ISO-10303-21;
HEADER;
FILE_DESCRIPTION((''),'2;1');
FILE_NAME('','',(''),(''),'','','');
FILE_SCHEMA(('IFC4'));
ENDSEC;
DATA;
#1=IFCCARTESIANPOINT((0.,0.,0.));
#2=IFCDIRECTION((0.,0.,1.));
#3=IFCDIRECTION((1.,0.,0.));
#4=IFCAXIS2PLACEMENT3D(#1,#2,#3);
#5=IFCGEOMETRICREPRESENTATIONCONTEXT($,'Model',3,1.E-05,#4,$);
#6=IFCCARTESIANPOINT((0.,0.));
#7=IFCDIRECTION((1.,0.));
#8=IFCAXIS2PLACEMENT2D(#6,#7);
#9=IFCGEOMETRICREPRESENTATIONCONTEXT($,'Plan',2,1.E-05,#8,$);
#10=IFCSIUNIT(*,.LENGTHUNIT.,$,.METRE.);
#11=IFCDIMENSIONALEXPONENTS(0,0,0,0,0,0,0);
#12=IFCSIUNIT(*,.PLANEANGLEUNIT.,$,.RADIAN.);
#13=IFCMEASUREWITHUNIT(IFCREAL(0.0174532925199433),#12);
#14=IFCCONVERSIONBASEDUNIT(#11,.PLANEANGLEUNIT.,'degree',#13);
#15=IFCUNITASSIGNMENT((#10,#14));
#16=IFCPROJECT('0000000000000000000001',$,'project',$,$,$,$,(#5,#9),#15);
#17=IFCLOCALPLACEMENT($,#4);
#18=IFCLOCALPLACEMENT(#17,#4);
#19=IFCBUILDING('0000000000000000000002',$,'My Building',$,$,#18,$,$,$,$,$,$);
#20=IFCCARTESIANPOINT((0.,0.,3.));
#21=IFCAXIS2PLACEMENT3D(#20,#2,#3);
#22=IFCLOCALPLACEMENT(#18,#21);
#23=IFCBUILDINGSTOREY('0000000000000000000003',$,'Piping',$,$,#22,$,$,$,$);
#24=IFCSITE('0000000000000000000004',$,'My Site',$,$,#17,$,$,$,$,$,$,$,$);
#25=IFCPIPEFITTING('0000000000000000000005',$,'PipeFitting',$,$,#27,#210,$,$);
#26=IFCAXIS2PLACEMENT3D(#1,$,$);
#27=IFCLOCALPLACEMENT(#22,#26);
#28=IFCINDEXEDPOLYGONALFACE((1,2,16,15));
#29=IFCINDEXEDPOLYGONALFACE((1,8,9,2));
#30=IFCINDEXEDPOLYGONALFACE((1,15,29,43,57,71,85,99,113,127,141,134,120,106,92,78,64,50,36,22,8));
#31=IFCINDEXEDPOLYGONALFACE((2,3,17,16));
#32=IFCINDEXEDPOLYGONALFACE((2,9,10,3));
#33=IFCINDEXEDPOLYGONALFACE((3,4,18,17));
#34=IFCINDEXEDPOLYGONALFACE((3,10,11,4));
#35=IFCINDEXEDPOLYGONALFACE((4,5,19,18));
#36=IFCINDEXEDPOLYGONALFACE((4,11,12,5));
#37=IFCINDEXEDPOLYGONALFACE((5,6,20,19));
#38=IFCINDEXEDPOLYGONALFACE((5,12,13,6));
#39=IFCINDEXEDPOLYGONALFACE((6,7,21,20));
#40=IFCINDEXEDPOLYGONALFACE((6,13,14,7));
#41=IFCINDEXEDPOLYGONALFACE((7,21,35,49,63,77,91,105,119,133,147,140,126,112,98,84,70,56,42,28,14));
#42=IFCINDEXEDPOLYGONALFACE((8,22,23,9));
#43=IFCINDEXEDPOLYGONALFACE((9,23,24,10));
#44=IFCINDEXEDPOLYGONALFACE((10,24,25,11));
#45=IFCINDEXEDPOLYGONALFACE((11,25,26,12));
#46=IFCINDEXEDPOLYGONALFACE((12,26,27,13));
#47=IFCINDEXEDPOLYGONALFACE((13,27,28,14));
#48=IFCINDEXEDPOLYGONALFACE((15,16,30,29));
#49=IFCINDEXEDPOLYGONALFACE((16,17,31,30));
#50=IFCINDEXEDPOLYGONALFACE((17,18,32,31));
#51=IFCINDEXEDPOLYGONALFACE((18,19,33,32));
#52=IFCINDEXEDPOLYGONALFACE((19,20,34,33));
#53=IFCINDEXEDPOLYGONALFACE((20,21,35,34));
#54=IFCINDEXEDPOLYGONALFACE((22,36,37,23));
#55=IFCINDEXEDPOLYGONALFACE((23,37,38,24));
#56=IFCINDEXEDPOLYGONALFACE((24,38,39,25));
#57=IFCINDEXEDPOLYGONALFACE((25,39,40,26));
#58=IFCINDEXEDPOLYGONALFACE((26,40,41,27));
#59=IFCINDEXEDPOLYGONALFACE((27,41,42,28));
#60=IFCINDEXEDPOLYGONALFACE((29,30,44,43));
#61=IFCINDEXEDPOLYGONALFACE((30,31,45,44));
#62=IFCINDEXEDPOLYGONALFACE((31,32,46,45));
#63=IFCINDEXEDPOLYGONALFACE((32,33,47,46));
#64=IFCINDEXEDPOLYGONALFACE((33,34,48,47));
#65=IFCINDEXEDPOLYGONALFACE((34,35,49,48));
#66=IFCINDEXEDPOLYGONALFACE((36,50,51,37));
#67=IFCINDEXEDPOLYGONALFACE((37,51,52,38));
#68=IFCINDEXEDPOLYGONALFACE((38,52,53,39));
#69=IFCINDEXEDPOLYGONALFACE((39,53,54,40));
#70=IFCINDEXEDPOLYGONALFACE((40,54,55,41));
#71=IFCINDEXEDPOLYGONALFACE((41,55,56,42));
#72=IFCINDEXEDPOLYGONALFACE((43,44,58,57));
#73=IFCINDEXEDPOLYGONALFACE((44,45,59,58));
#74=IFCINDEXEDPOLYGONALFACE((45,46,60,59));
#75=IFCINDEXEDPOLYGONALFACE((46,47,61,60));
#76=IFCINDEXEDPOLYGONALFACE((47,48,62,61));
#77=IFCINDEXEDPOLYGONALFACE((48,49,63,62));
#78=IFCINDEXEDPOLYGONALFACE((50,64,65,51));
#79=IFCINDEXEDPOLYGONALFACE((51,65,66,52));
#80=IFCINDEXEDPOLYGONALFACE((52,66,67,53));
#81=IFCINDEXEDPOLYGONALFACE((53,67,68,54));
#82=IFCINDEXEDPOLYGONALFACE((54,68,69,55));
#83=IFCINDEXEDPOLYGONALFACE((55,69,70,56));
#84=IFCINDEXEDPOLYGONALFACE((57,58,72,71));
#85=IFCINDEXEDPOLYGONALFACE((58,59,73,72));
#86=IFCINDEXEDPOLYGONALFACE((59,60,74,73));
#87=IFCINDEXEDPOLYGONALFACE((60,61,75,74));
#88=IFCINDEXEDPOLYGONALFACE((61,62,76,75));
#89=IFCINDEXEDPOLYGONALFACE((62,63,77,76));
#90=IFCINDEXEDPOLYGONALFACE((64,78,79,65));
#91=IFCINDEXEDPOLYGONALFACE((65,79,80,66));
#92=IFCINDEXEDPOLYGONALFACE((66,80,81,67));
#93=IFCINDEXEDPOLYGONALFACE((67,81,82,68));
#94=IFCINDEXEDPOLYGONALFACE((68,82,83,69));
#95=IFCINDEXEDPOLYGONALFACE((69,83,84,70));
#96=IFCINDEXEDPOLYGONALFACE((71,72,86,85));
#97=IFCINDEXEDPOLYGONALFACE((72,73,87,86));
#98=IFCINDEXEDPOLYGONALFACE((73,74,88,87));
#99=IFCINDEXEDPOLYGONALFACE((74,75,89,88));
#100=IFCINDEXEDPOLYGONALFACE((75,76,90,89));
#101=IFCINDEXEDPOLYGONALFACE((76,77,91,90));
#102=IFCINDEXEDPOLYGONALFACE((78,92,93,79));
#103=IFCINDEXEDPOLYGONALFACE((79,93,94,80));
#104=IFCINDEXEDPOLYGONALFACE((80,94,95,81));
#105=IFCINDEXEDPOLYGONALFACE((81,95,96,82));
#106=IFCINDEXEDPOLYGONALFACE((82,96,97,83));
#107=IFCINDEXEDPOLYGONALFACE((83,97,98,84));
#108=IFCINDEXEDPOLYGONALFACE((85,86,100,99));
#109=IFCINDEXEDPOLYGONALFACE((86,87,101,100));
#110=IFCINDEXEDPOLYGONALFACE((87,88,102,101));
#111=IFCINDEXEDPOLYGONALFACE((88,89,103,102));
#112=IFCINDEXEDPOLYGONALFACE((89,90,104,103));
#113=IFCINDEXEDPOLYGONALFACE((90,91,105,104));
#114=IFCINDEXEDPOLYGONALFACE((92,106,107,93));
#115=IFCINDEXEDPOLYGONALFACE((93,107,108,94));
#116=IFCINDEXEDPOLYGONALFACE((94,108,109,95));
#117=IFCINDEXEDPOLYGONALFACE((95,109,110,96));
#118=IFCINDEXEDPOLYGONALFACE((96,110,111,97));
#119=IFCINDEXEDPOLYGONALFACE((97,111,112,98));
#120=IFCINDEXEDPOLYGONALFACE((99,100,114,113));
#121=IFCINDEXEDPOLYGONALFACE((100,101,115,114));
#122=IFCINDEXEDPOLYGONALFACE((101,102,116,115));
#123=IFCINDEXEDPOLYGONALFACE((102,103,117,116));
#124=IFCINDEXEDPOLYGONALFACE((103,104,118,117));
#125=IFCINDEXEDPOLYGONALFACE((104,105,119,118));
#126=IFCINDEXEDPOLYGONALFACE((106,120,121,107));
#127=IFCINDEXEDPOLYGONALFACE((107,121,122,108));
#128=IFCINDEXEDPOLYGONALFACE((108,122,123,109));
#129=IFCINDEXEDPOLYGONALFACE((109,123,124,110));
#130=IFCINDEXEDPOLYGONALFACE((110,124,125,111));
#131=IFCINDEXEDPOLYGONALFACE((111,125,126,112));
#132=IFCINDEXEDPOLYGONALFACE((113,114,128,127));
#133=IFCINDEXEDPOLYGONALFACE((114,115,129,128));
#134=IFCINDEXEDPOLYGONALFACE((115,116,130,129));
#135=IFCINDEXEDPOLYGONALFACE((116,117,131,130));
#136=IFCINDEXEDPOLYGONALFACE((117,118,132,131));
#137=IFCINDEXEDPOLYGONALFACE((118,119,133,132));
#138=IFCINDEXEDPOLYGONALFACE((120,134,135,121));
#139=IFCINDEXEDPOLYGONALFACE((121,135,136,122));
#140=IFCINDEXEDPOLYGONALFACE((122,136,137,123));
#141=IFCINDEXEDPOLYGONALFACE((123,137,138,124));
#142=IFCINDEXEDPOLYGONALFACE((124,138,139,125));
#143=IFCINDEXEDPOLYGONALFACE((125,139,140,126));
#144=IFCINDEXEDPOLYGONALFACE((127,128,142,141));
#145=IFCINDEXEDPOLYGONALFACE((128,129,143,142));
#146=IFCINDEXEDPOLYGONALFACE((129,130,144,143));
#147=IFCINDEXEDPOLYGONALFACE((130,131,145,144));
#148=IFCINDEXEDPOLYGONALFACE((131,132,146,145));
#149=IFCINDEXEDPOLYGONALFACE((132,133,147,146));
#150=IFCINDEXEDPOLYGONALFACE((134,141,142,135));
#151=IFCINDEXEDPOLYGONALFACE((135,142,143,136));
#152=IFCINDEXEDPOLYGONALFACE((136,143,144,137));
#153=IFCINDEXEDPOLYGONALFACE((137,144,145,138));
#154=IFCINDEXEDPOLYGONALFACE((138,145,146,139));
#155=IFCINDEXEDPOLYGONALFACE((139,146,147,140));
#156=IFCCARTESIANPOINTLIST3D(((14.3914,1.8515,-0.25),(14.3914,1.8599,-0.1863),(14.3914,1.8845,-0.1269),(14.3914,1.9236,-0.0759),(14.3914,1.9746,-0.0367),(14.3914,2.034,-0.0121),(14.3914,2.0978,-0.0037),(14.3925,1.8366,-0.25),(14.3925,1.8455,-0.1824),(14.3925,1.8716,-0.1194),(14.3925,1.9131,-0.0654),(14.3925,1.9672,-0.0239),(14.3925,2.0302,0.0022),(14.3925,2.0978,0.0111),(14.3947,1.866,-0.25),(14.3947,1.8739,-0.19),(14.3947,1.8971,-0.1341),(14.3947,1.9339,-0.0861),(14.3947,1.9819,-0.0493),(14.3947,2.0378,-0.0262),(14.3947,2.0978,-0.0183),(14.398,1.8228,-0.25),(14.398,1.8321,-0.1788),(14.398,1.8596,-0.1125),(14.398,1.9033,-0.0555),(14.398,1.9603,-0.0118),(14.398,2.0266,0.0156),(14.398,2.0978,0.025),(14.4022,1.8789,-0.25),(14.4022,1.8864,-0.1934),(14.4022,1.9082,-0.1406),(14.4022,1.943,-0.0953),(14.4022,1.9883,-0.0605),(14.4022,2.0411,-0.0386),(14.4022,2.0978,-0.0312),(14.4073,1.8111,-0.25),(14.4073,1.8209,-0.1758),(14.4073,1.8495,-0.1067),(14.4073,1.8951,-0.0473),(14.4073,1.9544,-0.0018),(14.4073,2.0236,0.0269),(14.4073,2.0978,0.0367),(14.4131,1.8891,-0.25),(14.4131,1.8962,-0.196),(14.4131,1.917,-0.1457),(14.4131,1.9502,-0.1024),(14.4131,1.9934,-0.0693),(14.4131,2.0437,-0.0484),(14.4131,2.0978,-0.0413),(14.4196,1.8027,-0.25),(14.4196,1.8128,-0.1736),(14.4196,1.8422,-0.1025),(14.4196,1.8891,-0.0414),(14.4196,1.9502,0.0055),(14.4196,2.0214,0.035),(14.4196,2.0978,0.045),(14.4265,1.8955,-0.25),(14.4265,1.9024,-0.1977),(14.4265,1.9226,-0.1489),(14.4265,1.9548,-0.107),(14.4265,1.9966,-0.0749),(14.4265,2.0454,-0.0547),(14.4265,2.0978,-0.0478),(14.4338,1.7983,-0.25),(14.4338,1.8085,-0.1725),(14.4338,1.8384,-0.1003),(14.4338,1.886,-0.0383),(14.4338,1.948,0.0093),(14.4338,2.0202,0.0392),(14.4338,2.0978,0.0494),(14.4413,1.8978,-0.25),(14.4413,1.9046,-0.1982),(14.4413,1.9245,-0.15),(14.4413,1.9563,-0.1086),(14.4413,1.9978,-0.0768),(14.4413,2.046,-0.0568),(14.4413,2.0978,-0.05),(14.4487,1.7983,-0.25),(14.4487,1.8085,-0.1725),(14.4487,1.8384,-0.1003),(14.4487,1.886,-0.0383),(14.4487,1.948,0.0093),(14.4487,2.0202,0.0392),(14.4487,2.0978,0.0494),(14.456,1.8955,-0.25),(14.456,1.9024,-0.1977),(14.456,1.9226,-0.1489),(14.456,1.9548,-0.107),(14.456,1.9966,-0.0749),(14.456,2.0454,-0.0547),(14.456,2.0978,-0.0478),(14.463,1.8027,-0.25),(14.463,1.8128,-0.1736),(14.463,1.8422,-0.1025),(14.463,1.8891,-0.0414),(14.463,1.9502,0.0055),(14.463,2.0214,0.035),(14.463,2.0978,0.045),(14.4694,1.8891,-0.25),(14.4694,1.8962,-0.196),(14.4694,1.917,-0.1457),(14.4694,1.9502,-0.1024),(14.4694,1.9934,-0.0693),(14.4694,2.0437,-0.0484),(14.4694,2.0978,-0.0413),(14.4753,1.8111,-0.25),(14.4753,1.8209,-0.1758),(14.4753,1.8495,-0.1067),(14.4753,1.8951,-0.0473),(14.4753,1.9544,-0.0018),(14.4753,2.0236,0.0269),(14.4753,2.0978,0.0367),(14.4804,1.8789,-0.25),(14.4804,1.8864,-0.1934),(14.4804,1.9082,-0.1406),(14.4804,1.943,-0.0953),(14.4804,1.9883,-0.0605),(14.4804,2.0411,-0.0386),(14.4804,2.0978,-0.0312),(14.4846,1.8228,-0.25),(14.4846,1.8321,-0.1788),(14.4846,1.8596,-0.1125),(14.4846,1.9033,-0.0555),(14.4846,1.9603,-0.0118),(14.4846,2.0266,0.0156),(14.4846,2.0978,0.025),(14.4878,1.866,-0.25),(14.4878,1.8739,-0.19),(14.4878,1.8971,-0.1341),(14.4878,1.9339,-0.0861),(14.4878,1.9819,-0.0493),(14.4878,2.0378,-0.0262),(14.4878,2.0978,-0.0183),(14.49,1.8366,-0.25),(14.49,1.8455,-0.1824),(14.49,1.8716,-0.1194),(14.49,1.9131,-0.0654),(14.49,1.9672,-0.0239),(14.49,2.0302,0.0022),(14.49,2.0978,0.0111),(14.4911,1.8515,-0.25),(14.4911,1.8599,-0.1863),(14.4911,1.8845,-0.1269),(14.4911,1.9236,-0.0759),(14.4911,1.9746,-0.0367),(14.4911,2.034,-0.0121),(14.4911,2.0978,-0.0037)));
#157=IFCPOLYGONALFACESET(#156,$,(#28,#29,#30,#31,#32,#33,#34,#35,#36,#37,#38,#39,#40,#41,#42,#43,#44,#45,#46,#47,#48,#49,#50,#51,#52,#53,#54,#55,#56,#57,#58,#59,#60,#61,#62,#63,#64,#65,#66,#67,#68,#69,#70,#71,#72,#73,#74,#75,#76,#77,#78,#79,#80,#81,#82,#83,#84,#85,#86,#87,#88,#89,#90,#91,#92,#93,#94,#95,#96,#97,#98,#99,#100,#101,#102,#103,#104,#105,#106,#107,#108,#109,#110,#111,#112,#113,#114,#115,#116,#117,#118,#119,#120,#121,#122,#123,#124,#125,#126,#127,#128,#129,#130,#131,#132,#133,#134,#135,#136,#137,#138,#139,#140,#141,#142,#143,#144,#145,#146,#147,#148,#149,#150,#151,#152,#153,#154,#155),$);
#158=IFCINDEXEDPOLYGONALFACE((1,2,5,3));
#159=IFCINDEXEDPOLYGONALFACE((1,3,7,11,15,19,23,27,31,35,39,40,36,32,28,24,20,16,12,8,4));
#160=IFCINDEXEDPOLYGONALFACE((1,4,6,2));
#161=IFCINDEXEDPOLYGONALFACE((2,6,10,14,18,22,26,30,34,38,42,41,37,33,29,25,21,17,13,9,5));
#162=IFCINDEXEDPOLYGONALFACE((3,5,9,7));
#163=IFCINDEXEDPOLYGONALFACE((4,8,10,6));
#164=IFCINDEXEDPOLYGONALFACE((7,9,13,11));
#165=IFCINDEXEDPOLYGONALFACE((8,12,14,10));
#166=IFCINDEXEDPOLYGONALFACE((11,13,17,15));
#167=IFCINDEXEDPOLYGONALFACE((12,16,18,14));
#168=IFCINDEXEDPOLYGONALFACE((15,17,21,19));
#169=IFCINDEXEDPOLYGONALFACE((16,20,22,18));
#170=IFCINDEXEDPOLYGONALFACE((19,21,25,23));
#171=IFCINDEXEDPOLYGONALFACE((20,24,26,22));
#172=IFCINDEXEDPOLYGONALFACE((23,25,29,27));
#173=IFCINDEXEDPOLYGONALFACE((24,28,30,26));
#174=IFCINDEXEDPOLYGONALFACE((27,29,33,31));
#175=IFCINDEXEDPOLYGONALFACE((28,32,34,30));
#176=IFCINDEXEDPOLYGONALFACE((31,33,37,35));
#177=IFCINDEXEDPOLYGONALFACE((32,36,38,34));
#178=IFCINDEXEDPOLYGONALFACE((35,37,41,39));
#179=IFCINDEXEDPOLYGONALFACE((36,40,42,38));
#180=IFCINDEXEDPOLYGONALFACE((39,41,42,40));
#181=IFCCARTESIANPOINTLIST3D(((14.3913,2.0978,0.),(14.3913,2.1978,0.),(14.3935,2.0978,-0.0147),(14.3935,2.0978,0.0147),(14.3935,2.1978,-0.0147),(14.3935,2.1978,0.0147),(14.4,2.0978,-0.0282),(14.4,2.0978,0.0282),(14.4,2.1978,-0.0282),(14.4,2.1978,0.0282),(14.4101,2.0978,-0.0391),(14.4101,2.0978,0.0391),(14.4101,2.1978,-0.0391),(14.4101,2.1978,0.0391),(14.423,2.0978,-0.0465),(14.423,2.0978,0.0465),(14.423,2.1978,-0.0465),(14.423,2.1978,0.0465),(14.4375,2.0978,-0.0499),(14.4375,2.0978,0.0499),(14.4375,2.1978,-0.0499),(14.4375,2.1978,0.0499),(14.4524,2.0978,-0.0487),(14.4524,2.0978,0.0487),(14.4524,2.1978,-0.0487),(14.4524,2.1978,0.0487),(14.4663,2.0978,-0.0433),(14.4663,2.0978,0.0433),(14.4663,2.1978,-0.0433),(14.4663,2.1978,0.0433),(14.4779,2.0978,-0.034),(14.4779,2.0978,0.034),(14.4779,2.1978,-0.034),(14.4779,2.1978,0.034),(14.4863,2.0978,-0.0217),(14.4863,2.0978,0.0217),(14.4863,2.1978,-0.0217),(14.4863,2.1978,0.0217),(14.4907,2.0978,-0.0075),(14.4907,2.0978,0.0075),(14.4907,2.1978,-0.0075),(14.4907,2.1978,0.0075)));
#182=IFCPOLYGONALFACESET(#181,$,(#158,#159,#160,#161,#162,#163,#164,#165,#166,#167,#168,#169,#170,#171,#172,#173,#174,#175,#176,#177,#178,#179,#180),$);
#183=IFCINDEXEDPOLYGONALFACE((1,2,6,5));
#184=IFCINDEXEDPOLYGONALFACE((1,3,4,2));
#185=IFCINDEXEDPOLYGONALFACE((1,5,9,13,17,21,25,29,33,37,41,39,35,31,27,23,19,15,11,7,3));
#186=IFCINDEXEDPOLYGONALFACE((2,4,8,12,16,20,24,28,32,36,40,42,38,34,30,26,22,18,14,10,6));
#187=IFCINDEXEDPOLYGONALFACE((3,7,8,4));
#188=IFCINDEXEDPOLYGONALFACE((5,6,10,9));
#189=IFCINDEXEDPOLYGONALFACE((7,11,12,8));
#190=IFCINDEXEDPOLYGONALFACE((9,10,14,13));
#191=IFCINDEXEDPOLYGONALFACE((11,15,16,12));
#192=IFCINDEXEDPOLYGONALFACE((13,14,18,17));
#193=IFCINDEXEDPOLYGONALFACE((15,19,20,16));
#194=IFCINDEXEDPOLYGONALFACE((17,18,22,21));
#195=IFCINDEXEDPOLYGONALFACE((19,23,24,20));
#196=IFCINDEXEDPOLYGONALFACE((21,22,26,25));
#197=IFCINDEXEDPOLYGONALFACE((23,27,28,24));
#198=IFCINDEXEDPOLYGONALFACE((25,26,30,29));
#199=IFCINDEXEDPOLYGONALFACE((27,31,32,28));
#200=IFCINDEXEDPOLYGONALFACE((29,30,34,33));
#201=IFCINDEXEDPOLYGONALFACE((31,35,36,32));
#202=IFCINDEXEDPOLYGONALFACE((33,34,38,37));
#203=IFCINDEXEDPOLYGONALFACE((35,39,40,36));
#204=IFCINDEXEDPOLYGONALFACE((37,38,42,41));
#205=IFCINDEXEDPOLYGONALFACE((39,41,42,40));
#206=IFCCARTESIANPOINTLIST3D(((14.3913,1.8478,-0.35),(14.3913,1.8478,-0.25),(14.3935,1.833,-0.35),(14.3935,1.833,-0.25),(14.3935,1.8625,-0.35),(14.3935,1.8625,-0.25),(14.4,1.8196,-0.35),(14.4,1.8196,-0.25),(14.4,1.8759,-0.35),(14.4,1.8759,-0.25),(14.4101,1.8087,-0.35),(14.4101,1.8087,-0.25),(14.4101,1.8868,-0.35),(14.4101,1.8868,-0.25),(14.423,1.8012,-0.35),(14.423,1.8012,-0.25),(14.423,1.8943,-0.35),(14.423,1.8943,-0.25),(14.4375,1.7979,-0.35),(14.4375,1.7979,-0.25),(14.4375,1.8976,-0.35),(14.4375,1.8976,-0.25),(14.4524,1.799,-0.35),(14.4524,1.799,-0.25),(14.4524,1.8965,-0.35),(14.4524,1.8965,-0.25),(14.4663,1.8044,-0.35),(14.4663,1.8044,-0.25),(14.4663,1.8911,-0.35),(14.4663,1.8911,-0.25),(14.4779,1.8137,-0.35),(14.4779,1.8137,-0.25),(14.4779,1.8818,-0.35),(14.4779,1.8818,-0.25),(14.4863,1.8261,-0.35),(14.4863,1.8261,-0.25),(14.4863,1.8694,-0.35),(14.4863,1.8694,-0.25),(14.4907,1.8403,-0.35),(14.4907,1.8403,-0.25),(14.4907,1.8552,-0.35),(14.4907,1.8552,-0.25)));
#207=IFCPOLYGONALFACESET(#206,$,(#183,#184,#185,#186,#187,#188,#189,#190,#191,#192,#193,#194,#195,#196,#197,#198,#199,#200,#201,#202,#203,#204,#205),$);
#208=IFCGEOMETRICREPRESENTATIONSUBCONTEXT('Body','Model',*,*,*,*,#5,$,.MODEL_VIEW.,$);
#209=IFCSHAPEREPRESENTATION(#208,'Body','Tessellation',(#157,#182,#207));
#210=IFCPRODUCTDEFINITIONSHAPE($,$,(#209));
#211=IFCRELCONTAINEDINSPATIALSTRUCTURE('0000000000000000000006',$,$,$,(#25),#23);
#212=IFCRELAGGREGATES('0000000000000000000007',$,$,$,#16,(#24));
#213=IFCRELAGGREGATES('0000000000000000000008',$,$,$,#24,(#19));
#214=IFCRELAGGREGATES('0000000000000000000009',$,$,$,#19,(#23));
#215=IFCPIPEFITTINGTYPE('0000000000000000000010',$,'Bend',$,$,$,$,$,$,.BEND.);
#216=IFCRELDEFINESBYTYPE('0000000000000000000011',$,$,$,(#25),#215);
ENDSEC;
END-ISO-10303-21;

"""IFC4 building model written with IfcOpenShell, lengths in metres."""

from ifc_helpers import new_model, entity, si_unit, converted_unit, frame, origin_with_axes, origin_2d_with_axis, place, context, subcontext, project, spatial, circle, extrude, source, transform, mapped, type_object, type_shapes, element, save


model = new_model("IFC4")

# Units and contexts
model_context = context("Model", 3, precision=1e-05, world=origin_with_axes())
plan_context = context("Plan", 2, precision=1e-05, world=origin_2d_with_axis())
body_context = subcontext(model_context, "Body", "Model", "MODEL_VIEW")
ifc_project = project(units=[si_unit("LENGTHUNIT", "METRE"), converted_unit("PLANEANGLEUNIT", "degree", entity("IfcReal", 0.0174532925199433), si_unit("PLANEANGLEUNIT", "RADIAN"), dimensions=[0, 0, 0, 0, 0, 0, 0])], contexts=[model_context, plan_context])

# Site, building, storey
site_placement = place(None, origin_with_axes())
site = spatial("IfcSite", under=ifc_project, at=site_placement, Name="My Site")
building_placement = place(site_placement, origin_with_axes())
building = spatial("IfcBuilding", under=site, at=building_placement, Name="My Building")
storey_placement = place(building_placement, frame((0.0, 0.0, 3.0), z_axis=(0.0, 0.0, 1.0), x_axis=(1.0, 0.0, 0.0)))
storey = spatial("IfcBuildingStorey", under=building, at=storey_placement, Name="Piping")

# Pipe fitting
pipe_fitting_type = type_object("IfcPipeFittingType", Name="Bend", PredefinedType="BEND")
shared_shape = source(origin_with_axes(), body_context, "Body", "SolidModel", [
    entity("IfcSweptDiskSolid", entity("IfcIndexedPolyCurve", entity("IfcCartesianPointList3D", [[0.0, 0.0, -0.1], [0.0, -0.0732, -0.2768], [0.0, -0.25, -0.35]]), [entity("IfcArcIndex", [1, 2, 3])]), 0.05),
    extrude(circle(Radius=0.05), origin_with_axes(), (0.0, 0.0, -1.0), 0.1),
    extrude(circle(Radius=0.05), frame((0.0, -0.25, -0.35), z_axis=(0.0, -1.0, 0.0), x_axis=(1.0, 0.0, 0.0)), (0.0, 0.0, 1.0), 0.1),
])
type_shapes(pipe_fitting_type, [shared_shape])
for number, where, z_axis, x_axis, name in (
    (1, (14.4413, 2.1978, 0.0), (0.0, 1.0, 0.0), (-1.0, 0.0, 0.0), "PipeFitting"),
):
    element("IfcPipeFitting", number, at=place(storey_placement, frame(where, z_axis=z_axis, x_axis=x_axis)), inside=storey, type_object=pipe_fitting_type, Name=name, context=body_context, shape_type="MappedRepresentation", body=[
        mapped(shared_shape, transform((0.0, 0.0, 0.0), x_axis=(1.0, 0.0, 0.0), y_axis=(0.0, 1.0, 0.0), z_axis=(0.0, 0.0, 1.0), scale=1.0)),
    ])

save(model, "model.ifc")
